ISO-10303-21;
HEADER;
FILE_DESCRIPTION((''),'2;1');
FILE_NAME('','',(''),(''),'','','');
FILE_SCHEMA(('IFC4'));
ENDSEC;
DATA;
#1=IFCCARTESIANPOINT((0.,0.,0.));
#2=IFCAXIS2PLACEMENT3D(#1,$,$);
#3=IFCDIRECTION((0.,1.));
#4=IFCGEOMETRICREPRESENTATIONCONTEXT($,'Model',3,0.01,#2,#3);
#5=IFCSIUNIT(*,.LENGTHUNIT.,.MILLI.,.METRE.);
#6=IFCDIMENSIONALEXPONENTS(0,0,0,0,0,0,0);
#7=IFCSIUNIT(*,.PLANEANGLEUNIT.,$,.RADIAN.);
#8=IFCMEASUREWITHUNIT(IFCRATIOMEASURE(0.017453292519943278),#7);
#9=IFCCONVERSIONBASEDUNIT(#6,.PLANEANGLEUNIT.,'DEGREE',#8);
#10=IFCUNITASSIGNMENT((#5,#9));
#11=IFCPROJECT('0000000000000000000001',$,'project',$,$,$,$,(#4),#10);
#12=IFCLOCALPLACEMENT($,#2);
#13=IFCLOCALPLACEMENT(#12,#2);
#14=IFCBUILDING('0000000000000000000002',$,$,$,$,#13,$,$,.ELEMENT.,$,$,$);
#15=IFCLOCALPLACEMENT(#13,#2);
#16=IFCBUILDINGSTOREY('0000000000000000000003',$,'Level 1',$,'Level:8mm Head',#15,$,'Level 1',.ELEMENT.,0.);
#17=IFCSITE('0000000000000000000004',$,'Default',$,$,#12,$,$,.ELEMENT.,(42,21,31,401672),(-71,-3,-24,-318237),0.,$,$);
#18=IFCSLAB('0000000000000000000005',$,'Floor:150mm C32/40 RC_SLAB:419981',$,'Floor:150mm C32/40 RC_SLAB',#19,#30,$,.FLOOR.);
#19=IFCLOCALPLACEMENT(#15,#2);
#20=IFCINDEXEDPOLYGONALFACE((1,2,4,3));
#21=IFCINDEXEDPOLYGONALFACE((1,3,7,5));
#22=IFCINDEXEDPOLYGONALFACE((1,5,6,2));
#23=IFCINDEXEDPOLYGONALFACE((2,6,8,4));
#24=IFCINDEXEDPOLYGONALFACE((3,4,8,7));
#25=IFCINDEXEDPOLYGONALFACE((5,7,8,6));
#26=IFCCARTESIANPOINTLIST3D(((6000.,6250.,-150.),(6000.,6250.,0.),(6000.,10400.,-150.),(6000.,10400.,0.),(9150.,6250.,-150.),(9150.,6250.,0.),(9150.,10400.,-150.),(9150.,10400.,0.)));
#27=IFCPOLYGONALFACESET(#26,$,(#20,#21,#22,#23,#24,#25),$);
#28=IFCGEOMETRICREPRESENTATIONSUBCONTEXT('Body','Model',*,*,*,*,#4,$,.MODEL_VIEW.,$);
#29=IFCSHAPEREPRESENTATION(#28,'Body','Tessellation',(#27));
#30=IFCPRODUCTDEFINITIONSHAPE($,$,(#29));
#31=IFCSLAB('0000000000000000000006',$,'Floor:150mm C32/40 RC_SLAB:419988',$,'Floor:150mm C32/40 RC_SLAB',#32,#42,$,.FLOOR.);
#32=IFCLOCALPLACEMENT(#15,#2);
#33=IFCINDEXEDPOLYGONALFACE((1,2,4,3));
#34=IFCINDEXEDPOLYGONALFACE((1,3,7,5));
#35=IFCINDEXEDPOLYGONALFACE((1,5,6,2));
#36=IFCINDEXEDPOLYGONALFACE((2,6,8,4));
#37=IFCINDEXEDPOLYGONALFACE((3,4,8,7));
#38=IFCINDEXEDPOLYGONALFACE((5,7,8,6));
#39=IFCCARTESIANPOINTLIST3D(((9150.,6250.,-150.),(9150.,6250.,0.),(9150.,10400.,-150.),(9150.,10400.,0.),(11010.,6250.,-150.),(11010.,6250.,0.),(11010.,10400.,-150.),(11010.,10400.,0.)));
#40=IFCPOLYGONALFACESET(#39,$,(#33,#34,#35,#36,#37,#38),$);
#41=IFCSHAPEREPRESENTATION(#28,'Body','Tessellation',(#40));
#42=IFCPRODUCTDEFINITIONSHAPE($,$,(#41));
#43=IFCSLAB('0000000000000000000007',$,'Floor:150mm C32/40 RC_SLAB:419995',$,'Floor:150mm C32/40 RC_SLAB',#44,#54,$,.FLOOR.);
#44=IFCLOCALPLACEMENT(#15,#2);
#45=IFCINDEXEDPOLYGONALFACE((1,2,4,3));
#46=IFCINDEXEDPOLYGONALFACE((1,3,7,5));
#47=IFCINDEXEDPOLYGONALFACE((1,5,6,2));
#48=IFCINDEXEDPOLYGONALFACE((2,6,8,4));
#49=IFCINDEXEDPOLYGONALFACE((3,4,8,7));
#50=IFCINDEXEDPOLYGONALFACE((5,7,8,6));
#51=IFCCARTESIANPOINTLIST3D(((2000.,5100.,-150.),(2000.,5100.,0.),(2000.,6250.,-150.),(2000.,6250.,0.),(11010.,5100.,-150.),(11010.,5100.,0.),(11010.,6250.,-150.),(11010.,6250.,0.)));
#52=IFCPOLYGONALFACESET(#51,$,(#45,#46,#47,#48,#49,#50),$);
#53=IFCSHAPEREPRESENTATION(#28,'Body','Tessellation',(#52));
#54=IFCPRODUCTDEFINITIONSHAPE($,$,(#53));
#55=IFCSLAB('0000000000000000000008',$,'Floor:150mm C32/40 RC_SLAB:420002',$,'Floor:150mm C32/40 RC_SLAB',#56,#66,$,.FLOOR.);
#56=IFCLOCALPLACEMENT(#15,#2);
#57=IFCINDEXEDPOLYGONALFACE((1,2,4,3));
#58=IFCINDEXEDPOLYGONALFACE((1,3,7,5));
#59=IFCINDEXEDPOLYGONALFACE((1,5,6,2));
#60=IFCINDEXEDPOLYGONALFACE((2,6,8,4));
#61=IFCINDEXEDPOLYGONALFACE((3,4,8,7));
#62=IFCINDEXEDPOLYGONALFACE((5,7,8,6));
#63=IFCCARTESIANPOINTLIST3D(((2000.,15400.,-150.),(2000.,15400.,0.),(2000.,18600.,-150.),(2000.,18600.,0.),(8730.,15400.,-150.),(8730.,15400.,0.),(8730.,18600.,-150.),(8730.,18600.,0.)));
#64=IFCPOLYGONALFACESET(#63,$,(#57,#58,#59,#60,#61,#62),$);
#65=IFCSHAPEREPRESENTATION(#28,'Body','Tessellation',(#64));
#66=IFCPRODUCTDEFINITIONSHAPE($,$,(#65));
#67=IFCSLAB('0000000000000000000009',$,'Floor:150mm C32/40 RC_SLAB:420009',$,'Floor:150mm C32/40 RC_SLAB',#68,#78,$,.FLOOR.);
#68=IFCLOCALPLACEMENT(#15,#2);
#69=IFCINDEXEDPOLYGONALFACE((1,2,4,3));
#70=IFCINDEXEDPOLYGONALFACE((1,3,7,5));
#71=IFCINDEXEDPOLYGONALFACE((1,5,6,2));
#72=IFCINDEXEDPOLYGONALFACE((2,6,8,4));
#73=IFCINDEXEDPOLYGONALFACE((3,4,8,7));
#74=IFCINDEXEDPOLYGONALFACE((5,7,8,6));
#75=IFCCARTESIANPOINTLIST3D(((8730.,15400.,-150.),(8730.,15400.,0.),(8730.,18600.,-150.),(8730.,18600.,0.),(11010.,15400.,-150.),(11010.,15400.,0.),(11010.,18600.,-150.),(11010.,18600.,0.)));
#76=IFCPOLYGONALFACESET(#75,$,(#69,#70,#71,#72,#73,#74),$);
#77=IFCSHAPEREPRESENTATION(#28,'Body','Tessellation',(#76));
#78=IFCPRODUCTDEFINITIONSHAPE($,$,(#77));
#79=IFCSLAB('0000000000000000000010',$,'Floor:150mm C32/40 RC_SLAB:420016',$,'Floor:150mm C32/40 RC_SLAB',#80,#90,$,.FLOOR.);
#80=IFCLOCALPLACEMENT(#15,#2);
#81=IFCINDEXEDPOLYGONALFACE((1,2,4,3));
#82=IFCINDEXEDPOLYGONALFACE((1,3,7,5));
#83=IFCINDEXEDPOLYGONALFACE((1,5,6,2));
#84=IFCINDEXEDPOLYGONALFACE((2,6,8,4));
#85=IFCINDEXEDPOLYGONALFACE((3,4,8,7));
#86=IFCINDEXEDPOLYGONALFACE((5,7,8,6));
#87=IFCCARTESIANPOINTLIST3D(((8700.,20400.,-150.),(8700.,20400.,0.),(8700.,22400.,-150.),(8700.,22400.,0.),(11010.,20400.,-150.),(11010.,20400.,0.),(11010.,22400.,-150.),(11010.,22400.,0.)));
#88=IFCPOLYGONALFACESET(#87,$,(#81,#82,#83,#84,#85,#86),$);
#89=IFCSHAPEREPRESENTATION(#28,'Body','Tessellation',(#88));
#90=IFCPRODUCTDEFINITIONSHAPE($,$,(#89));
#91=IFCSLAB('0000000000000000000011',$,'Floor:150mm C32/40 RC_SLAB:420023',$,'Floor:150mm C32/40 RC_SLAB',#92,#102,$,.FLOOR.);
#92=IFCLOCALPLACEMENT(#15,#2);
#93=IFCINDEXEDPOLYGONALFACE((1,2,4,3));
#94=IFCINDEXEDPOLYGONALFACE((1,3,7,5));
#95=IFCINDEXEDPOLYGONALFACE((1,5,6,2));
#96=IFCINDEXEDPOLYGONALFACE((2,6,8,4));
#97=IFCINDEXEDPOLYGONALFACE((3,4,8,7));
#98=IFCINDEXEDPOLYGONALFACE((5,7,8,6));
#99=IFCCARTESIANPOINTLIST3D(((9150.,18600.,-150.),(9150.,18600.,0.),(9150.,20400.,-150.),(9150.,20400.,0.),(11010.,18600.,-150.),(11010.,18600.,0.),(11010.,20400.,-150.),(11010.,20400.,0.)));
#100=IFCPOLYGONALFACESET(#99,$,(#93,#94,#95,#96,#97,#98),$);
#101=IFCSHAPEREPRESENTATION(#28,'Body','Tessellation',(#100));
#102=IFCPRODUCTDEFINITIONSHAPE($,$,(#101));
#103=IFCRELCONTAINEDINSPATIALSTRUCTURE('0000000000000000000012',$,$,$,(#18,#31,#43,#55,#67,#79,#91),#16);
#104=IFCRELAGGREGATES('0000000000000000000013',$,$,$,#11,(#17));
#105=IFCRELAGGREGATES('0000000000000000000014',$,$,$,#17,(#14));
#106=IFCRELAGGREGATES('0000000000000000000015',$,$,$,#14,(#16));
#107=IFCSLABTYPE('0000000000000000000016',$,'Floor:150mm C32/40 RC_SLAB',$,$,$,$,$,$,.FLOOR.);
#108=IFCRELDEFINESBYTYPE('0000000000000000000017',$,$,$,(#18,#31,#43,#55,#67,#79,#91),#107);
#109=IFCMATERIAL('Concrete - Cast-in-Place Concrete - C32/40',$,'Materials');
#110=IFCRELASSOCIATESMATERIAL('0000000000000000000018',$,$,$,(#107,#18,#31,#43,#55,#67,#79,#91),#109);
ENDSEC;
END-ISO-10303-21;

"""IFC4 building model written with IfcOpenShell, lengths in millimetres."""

from ifc_helpers import new_model, entity, si_unit, converted_unit, direction, frame, origin, place, context, subcontext, project, spatial, indexed_curve, outline, extrude, material, type_object, element, save


model = new_model("IFC4")

# Units and contexts
model_context = context("Model", 3, precision=0.01, world=origin(), true_north=direction((0.0, 1.0)))
body_context = subcontext(model_context, "Body", "Model", "MODEL_VIEW")
ifc_project = project(units=[si_unit("LENGTHUNIT", "METRE", prefix="MILLI"), converted_unit("PLANEANGLEUNIT", "DEGREE", entity("IfcRatioMeasure", 0.017453292519943278), si_unit("PLANEANGLEUNIT", "RADIAN"), dimensions=[0, 0, 0, 0, 0, 0, 0])], contexts=[model_context])

# Site, building, storey
site_placement = place(None, origin())
site = spatial("IfcSite", under=ifc_project, at=site_placement, Name="Default", CompositionType="ELEMENT", RefLatitude=(42, 21, 31, 401672), RefLongitude=(-71, -3, -24, -318237), RefElevation=0.0)
building_placement = place(site_placement, origin())
building = spatial("IfcBuilding", under=site, at=building_placement, CompositionType="ELEMENT")
storey_placement = place(building_placement, origin())
storey = spatial("IfcBuildingStorey", under=building, at=storey_placement, Name="Level 1", ObjectType="Level:8mm Head", LongName="Level 1", CompositionType="ELEMENT", Elevation=0.0)

# Shared definitions
ifc_material = material(Name="Concrete - Cast-in-Place Concrete - C32/40", Category="Materials")

# Slabs
slab_type = type_object("IfcSlabType", Name="Floor:150mm C32/40 RC_SLAB", PredefinedType="FLOOR", material=ifc_material)
slab_1_placement = place(storey_placement, origin())
element("IfcSlab", 1, at=slab_1_placement, inside=storey, type_object=slab_type, material=ifc_material, Name="Floor:150mm C32/40 RC_SLAB:419981", ObjectType="Floor:150mm C32/40 RC_SLAB", PredefinedType="FLOOR", context=body_context, shape_type="SweptSolid", body=[
    extrude(outline(indexed_curve([(-2075.0, -1575.0), (2075.0, -1575.0), (2075.0, 1575.0), (-2075.0, 1575.0), (-2075.0, -1575.0)], self_intersect=False)), frame((7575.0, 8325.0, 0.0), z_axis=(0.0, 0.0, -1.0), x_axis=(0.0, 1.0, 0.0)), (0.0, 0.0, 1.0), 150.0),
])
slab_2_placement = place(storey_placement, origin())
element("IfcSlab", 2, at=slab_2_placement, inside=storey, type_object=slab_type, material=ifc_material, Name="Floor:150mm C32/40 RC_SLAB:419988", ObjectType="Floor:150mm C32/40 RC_SLAB", PredefinedType="FLOOR", context=body_context, shape_type="SweptSolid", body=[
    extrude(outline(indexed_curve([(-2075.0, -930.0), (2075.0, -930.0), (2075.0, 930.0), (-2075.0, 930.0), (-2075.0, -930.0)], self_intersect=False)), frame((10080.0, 8325.0, 0.0), z_axis=(0.0, 0.0, -1.0), x_axis=(0.0, 1.0, 0.0)), (0.0, 0.0, 1.0), 150.0),
])
slab_3_placement = place(storey_placement, origin())
element("IfcSlab", 3, at=slab_3_placement, inside=storey, type_object=slab_type, material=ifc_material, Name="Floor:150mm C32/40 RC_SLAB:419995", ObjectType="Floor:150mm C32/40 RC_SLAB", PredefinedType="FLOOR", context=body_context, shape_type="SweptSolid", body=[
    extrude(outline(indexed_curve([(-575.0, -4505.0), (575.0, -4505.0), (575.0, 4505.0), (-575.0, 4505.0), (-575.0, -4505.0)], self_intersect=False)), frame((6505.0, 5675.0, 0.0), z_axis=(0.0, 0.0, -1.0), x_axis=(0.0, 1.0, 0.0)), (0.0, 0.0, 1.0), 150.0),
])
slab_4_placement = place(storey_placement, origin())
element("IfcSlab", 4, at=slab_4_placement, inside=storey, type_object=slab_type, material=ifc_material, Name="Floor:150mm C32/40 RC_SLAB:420002", ObjectType="Floor:150mm C32/40 RC_SLAB", PredefinedType="FLOOR", context=body_context, shape_type="SweptSolid", body=[
    extrude(outline(indexed_curve([(-1600.0, -3365.0), (1600.0, -3365.0), (1600.0, 3365.0), (-1600.0, 3365.0), (-1600.0, -3365.0)], self_intersect=False)), frame((5365.0, 17000.0, 0.0), z_axis=(0.0, 0.0, -1.0), x_axis=(0.0, 1.0, 0.0)), (0.0, 0.0, 1.0), 150.0),
])
slab_5_placement = place(storey_placement, origin())
element("IfcSlab", 5, at=slab_5_placement, inside=storey, type_object=slab_type, material=ifc_material, Name="Floor:150mm C32/40 RC_SLAB:420009", ObjectType="Floor:150mm C32/40 RC_SLAB", PredefinedType="FLOOR", context=body_context, shape_type="SweptSolid", body=[
    extrude(outline(indexed_curve([(-1600.0, -1140.0), (1600.0, -1140.0), (1600.0, 1140.0), (-1600.0, 1140.0), (-1600.0, -1140.0)], self_intersect=False)), frame((9870.0, 17000.0, 0.0), z_axis=(0.0, 0.0, -1.0), x_axis=(0.0, 1.0, 0.0)), (0.0, 0.0, 1.0), 150.0),
])
slab_6_placement = place(storey_placement, origin())
element("IfcSlab", 6, at=slab_6_placement, inside=storey, type_object=slab_type, material=ifc_material, Name="Floor:150mm C32/40 RC_SLAB:420016", ObjectType="Floor:150mm C32/40 RC_SLAB", PredefinedType="FLOOR", context=body_context, shape_type="SweptSolid", body=[
    extrude(outline(indexed_curve([(-1000.0, -1155.0), (1000.0, -1155.0), (1000.0, 1155.0), (-1000.0, 1155.0), (-1000.0, -1155.0)], self_intersect=False)), frame((9855.0, 21400.0, 0.0), z_axis=(0.0, 0.0, -1.0), x_axis=(0.0, 1.0, 0.0)), (0.0, 0.0, 1.0), 150.0),
])
slab_7_placement = place(storey_placement, origin())
element("IfcSlab", 7, at=slab_7_placement, inside=storey, type_object=slab_type, material=ifc_material, Name="Floor:150mm C32/40 RC_SLAB:420023", ObjectType="Floor:150mm C32/40 RC_SLAB", PredefinedType="FLOOR", context=body_context, shape_type="SweptSolid", body=[
    extrude(outline(indexed_curve([(-900.0, -930.0), (900.0, -930.0), (900.0, 930.0), (-900.0, 930.0), (-900.0, -930.0)], self_intersect=False)), frame((10080.0, 19500.0, 0.0), z_axis=(0.0, 0.0, -1.0), x_axis=(0.0, 1.0, 0.0)), (0.0, 0.0, 1.0), 150.0),
])

save(model, "model.ifc")
